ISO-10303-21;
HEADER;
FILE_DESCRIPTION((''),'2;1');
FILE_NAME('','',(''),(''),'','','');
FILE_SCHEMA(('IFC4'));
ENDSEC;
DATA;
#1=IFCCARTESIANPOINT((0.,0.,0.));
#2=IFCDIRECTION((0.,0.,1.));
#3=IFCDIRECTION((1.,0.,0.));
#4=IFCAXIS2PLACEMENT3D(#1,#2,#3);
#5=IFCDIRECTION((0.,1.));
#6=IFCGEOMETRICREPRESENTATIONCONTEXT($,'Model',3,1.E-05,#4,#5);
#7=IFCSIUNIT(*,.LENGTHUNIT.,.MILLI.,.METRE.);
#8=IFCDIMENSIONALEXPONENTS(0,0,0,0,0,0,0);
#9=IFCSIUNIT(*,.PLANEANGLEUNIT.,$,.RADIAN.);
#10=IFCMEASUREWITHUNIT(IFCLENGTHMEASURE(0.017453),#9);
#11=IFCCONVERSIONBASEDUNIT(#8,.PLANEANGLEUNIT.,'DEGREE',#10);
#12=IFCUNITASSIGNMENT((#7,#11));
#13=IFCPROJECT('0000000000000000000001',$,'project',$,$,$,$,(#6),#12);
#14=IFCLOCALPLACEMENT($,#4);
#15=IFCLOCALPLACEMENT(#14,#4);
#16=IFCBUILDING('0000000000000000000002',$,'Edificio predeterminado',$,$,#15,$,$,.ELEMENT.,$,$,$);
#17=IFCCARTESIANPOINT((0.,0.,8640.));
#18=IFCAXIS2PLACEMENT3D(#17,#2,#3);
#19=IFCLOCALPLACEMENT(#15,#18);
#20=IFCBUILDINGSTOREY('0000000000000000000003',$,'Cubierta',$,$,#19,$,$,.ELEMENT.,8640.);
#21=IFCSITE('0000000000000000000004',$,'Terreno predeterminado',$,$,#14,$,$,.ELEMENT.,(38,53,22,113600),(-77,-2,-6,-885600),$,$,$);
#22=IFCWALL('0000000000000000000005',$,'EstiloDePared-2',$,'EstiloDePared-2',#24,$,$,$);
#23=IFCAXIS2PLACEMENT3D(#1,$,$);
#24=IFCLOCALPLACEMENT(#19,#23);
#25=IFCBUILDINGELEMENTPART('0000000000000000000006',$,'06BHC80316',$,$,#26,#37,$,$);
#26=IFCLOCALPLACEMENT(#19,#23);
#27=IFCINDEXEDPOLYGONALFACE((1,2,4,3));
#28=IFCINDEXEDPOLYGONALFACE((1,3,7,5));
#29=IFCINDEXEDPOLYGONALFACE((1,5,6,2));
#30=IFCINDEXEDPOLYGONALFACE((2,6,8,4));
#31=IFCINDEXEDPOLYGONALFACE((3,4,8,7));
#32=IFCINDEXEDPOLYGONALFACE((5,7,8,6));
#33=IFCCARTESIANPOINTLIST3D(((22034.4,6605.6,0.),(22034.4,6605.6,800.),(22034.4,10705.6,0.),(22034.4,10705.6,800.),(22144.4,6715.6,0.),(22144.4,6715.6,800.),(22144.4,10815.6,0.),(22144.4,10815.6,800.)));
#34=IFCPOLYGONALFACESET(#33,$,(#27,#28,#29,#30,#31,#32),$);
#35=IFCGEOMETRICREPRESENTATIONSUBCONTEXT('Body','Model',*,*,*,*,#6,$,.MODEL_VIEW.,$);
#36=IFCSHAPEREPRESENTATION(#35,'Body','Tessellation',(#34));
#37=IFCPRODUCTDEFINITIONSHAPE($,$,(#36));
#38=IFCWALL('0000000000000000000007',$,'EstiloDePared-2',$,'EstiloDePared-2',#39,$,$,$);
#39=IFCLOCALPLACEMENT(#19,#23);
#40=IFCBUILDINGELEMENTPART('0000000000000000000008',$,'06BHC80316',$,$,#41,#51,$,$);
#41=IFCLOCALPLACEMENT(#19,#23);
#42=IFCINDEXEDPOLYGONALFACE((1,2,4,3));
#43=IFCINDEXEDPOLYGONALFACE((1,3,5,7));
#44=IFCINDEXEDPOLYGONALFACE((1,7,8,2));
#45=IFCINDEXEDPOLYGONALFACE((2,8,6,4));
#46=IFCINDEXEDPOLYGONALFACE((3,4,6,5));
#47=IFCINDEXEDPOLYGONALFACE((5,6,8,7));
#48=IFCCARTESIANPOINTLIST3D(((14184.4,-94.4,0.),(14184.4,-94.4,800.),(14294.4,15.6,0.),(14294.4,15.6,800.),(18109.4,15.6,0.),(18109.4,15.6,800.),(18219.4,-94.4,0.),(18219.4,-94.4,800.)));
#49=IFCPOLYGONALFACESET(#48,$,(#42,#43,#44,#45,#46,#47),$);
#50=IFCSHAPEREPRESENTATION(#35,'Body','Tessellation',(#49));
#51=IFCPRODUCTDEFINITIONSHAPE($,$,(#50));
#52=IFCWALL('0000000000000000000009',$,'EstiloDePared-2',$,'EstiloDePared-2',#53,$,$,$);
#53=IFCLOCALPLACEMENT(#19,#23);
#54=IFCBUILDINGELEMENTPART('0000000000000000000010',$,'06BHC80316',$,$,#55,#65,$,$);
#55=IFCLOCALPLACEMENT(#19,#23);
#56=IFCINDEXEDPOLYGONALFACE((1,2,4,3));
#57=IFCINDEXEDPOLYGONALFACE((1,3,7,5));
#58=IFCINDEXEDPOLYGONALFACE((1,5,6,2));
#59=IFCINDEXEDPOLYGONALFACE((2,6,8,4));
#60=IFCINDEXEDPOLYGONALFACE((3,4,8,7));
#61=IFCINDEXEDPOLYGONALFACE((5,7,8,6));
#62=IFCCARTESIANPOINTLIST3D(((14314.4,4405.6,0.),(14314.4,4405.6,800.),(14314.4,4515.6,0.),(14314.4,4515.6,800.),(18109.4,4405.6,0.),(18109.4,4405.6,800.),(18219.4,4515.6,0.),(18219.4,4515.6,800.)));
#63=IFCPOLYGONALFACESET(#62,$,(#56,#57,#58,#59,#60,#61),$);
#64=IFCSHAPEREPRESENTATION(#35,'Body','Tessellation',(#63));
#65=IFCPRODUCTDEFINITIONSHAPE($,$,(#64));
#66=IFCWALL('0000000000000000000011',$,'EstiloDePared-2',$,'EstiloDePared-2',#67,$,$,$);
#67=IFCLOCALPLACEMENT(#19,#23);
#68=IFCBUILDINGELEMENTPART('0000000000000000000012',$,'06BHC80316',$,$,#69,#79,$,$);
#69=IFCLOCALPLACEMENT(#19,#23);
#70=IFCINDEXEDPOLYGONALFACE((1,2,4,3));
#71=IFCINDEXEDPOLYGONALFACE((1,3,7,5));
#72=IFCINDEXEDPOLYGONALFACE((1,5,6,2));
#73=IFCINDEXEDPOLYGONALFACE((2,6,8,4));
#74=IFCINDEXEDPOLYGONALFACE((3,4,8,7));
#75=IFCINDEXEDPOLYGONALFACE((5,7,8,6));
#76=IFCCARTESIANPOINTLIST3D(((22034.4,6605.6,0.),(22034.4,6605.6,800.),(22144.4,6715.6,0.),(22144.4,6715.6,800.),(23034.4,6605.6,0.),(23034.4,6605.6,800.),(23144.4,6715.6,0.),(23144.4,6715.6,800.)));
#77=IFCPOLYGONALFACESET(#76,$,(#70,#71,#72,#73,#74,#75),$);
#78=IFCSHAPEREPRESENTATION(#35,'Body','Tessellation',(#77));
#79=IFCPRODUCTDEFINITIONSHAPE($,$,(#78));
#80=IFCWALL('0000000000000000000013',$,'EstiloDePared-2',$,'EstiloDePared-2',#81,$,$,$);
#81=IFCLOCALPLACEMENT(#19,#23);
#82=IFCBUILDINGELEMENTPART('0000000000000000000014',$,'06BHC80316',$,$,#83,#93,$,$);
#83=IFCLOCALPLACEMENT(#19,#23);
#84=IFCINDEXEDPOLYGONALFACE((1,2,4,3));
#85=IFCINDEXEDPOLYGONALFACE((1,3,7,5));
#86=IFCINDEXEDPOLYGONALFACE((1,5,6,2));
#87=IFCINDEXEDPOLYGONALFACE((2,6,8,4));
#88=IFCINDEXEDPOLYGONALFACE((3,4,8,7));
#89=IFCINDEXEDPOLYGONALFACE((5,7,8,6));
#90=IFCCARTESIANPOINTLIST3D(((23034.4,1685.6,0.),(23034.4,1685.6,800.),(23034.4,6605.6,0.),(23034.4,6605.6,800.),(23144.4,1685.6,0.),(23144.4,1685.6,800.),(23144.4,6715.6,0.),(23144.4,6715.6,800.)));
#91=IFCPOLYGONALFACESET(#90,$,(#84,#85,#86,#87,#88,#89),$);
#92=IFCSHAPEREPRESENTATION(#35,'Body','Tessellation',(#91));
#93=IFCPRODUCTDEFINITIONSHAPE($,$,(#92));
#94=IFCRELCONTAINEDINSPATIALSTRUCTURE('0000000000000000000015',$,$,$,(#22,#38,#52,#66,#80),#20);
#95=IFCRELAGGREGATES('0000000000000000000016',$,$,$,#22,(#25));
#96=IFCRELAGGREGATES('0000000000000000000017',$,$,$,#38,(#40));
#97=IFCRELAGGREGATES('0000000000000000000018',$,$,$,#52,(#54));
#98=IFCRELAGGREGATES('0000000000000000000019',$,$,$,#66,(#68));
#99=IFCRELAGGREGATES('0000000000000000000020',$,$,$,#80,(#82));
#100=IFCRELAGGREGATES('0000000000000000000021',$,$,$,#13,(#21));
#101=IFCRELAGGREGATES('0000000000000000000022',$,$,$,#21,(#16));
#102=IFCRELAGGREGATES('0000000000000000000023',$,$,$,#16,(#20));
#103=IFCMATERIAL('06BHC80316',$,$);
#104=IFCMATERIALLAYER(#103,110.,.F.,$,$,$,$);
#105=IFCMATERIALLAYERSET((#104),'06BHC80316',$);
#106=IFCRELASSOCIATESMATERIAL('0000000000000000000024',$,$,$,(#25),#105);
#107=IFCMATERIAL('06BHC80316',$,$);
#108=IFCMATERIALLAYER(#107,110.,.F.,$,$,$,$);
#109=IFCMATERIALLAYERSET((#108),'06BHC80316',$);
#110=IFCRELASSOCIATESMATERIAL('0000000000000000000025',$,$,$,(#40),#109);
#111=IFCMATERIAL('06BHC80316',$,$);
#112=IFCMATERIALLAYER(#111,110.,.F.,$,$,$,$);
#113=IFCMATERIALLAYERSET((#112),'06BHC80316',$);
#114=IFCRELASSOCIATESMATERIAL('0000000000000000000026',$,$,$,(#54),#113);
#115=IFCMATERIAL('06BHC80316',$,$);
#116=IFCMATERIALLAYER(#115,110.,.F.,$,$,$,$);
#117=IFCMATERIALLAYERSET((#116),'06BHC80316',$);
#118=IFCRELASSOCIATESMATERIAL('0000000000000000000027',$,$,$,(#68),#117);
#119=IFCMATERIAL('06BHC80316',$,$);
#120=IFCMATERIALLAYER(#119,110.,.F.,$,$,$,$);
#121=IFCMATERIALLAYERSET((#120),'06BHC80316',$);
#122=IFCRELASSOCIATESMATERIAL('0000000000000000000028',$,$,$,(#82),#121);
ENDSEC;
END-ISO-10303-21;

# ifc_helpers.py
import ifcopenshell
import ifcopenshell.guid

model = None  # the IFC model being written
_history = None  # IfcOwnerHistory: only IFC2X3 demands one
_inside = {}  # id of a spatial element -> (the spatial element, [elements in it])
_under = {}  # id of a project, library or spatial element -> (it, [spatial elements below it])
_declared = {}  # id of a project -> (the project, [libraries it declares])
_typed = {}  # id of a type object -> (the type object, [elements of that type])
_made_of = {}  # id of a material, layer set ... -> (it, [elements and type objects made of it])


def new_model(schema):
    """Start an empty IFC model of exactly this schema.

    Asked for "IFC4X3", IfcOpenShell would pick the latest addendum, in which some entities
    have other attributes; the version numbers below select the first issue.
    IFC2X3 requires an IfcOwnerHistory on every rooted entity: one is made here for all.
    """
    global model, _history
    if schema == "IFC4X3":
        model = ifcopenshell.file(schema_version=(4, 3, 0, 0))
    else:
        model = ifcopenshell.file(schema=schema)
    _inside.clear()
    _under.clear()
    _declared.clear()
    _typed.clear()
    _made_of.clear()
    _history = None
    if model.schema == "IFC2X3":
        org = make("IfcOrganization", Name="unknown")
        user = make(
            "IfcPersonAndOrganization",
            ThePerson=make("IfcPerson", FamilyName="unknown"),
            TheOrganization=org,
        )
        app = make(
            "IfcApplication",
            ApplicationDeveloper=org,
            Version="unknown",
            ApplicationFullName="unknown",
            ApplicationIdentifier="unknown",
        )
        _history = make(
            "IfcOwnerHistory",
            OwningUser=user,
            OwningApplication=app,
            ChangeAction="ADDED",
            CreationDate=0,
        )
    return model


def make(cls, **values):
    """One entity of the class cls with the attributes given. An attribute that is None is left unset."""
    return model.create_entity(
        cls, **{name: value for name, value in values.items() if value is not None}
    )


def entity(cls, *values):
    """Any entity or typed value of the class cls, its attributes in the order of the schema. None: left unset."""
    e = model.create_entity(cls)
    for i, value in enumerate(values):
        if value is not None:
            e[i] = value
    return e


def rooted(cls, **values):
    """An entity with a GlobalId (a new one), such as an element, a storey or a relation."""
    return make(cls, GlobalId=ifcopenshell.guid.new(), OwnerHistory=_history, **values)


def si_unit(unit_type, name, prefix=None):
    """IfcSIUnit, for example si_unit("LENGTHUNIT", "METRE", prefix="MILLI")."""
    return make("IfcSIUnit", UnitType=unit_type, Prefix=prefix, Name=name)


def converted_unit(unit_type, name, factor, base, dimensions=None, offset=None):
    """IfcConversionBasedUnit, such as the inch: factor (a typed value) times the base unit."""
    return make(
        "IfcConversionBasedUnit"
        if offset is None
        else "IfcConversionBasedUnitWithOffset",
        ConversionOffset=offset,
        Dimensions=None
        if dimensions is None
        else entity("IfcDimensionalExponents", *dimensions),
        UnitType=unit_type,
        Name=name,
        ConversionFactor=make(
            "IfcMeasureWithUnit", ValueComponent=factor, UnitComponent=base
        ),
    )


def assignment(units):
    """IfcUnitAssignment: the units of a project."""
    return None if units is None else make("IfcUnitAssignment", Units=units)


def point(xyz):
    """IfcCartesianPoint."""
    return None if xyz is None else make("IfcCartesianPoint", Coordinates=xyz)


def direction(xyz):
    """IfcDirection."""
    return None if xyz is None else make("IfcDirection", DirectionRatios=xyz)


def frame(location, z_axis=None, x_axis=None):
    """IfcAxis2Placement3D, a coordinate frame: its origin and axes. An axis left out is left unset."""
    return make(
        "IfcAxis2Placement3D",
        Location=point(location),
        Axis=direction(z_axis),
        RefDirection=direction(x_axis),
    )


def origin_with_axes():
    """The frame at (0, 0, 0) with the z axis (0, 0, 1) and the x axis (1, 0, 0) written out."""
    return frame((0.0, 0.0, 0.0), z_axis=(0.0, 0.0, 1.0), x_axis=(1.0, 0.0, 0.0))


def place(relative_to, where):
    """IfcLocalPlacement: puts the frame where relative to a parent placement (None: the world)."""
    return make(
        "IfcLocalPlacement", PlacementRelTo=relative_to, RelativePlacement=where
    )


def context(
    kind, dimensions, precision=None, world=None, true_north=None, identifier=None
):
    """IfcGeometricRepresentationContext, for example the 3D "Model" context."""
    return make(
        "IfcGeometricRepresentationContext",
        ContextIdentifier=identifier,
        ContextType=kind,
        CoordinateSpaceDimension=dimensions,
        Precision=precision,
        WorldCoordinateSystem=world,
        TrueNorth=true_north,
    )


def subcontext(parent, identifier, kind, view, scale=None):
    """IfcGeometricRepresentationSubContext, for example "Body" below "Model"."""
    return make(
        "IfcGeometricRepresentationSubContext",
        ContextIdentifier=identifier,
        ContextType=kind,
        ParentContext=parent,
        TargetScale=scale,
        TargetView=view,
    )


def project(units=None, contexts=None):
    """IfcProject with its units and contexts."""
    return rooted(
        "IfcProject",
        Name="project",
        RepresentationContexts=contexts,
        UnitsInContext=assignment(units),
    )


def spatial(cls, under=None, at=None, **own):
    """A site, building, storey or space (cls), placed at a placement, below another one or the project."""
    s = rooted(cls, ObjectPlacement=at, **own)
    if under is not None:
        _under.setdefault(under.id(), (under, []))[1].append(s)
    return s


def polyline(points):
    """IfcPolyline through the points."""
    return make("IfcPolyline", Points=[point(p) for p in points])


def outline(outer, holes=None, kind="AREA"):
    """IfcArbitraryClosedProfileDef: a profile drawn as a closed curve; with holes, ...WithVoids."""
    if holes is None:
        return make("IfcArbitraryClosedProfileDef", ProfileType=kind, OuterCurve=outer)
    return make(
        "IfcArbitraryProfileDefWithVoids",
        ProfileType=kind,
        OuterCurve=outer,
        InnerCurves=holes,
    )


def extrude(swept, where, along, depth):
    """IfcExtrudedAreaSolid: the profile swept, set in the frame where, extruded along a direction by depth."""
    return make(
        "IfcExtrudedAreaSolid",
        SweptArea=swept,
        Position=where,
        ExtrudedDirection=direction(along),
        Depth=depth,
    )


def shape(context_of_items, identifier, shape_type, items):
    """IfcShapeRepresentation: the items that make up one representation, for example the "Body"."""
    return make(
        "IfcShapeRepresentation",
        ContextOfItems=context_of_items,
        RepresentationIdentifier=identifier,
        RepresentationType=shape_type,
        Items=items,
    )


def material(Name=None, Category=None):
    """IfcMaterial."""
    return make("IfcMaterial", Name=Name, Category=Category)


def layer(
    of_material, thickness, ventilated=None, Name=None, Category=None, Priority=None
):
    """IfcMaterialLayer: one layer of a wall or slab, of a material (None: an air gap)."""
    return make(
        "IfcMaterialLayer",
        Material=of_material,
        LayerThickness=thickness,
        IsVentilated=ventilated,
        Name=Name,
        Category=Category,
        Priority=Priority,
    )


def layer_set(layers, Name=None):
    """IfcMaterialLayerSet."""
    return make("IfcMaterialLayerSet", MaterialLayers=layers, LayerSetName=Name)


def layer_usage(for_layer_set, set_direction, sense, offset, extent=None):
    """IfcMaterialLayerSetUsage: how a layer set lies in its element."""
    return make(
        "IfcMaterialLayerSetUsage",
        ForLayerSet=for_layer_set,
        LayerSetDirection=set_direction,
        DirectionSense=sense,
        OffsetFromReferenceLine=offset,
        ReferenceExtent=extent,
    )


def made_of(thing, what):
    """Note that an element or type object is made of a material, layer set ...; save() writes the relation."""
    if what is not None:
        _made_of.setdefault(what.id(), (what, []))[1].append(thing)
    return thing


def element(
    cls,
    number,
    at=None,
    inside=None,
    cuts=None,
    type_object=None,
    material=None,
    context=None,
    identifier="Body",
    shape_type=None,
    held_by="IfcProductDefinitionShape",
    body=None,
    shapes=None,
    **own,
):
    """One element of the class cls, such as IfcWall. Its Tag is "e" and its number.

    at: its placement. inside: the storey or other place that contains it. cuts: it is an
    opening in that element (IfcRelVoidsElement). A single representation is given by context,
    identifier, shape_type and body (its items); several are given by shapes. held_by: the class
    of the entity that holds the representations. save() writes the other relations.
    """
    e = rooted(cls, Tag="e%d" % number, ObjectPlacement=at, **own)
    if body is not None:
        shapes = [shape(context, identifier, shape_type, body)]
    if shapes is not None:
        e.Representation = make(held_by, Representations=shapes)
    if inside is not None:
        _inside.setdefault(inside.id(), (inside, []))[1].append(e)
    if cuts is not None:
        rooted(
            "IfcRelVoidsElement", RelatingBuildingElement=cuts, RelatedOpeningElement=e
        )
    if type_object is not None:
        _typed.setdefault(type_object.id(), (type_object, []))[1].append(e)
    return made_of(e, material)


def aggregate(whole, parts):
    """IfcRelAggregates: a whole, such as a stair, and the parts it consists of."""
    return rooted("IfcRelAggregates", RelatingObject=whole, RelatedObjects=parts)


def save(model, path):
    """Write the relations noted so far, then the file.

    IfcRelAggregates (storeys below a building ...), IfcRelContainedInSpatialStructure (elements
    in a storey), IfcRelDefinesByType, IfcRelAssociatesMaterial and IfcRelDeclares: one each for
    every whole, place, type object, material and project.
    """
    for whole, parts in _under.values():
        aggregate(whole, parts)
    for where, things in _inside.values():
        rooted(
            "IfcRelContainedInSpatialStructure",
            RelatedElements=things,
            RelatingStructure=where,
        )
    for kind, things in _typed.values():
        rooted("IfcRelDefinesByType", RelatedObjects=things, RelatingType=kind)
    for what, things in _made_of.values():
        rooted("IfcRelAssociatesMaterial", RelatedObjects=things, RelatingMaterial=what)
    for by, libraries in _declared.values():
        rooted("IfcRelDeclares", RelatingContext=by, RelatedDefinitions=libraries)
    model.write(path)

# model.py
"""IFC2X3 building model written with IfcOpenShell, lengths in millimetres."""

from ifc_helpers import new_model, entity, si_unit, converted_unit, direction, frame, origin_with_axes, place, context, subcontext, project, spatial, polyline, outline, extrude, material, layer, layer_set, layer_usage, element, aggregate, save


model = new_model("IFC2X3")

# Units and contexts
model_context = context("Model", 3, precision=1e-05, world=origin_with_axes(), true_north=direction((0.0, 1.0)))
body_context = subcontext(model_context, "Body", "Model", "MODEL_VIEW")
ifc_project = project(units=[si_unit("LENGTHUNIT", "METRE", prefix="MILLI"), converted_unit("PLANEANGLEUNIT", "DEGREE", entity("IfcLengthMeasure", 0.017453), si_unit("PLANEANGLEUNIT", "RADIAN"), dimensions=[0, 0, 0, 0, 0, 0, 0])], contexts=[model_context])

# Site, building, storey
site_placement = place(None, origin_with_axes())
site = spatial("IfcSite", under=ifc_project, at=site_placement, Name="Terreno predeterminado", CompositionType="ELEMENT", RefLatitude=(38, 53, 22, 113600), RefLongitude=(-77, -2, -6, -885600))
building_placement = place(site_placement, origin_with_axes())
building = spatial("IfcBuilding", under=site, at=building_placement, Name="Edificio predeterminado", CompositionType="ELEMENT")
storey_placement = place(building_placement, frame((0.0, 0.0, 8640.0), z_axis=(0.0, 0.0, 1.0), x_axis=(1.0, 0.0, 0.0)))
storey = spatial("IfcBuildingStorey", under=building, at=storey_placement, Name="Cubierta", CompositionType="ELEMENT", Elevation=8640.0)

# Wall, building element part
wall_1_placement = place(storey_placement, frame((22089.4, 10760.6, 0.0), z_axis=(0.0, 0.0, 1.0), x_axis=(0.0, -1.0, 0.0)))
wall_1 = element("IfcWall", 1, at=wall_1_placement, inside=storey, Name="EstiloDePared-2", ObjectType="EstiloDePared-2")
ifc_material_1 = material(Name="06BHC80316")
ifc_layer_1 = layer(ifc_material_1, 110.0, ventilated=False)
ifc_layer_set_1 = layer_set([ifc_layer_1], Name="06BHC80316")
ifc_layer_usage_1 = layer_usage(ifc_layer_set_1, "AXIS2", "NEGATIVE", -55.0)
building_element_part_1_placement = place(wall_1_placement, origin_with_axes())
building_element_part_1 = element("IfcBuildingElementPart", 2, at=building_element_part_1_placement, material=ifc_layer_usage_1, Name="06BHC80316", context=body_context, shape_type="SweptSolid", body=[
    extrude(outline(polyline([(4045.0, 55.0), (4155.0, -55.0), (55.0, -55.0), (-55.0, 55.0), (4045.0, 55.0)])), origin_with_axes(), (0.0, 0.0, 1.0), 800.0),
])
aggregate(wall_1, [building_element_part_1])

# Walls, building element parts
wall_2_placement = place(storey_placement, frame((18164.4, -39.4, 0.0), z_axis=(0.0, 0.0, 1.0), x_axis=(-1.0, 0.0, 0.0)))
wall_2 = element("IfcWall", 3, at=wall_2_placement, inside=storey, Name="EstiloDePared-2", ObjectType="EstiloDePared-2")
ifc_material_2 = material(Name="06BHC80316")
ifc_layer_2 = layer(ifc_material_2, 110.0, ventilated=False)
ifc_layer_set_2 = layer_set([ifc_layer_2], Name="06BHC80316")
ifc_layer_usage_2 = layer_usage(ifc_layer_set_2, "AXIS2", "NEGATIVE", -55.0)
building_element_part_2_placement = place(wall_2_placement, origin_with_axes())
building_element_part_2 = element("IfcBuildingElementPart", 4, at=building_element_part_2_placement, material=ifc_layer_usage_2, Name="06BHC80316", context=body_context, shape_type="SweptSolid", body=[
    extrude(outline(polyline([(3980.0, 55.0), (3870.0, -55.0), (55.0, -55.0), (-55.0, 55.0), (3980.0, 55.0)])), origin_with_axes(), (0.0, 0.0, 1.0), 800.0),
])
aggregate(wall_2, [building_element_part_2])
wall_3_placement = place(storey_placement, frame((18164.4, 4460.6, 0.0), z_axis=(0.0, 0.0, 1.0), x_axis=(-1.0, 0.0, 0.0)))
wall_3 = element("IfcWall", 5, at=wall_3_placement, inside=storey, Name="EstiloDePared-2", ObjectType="EstiloDePared-2")
ifc_material_3 = material(Name="06BHC80316")
ifc_layer_3 = layer(ifc_material_3, 110.0, ventilated=False)
ifc_layer_set_3 = layer_set([ifc_layer_3], Name="06BHC80316")
ifc_layer_usage_3 = layer_usage(ifc_layer_set_3, "AXIS2", "NEGATIVE", -55.0)
building_element_part_3_placement = place(wall_3_placement, origin_with_axes())
building_element_part_3 = element("IfcBuildingElementPart", 6, at=building_element_part_3_placement, material=ifc_layer_usage_3, Name="06BHC80316", context=body_context, shape_type="SweptSolid", body=[
    extrude(outline(polyline([(3850.0, 55.0), (3850.0, -55.0), (-55.0, -55.0), (55.0, 55.0), (3850.0, 55.0)])), origin_with_axes(), (0.0, 0.0, 1.0), 800.0),
])
aggregate(wall_3, [building_element_part_3])
wall_4_placement = place(storey_placement, frame((22089.4, 6660.6, 0.0), z_axis=(0.0, 0.0, 1.0), x_axis=(1.0, 0.0, 0.0)))
wall_4 = element("IfcWall", 7, at=wall_4_placement, inside=storey, Name="EstiloDePared-2", ObjectType="EstiloDePared-2")
ifc_material_4 = material(Name="06BHC80316")
ifc_layer_4 = layer(ifc_material_4, 110.0, ventilated=False)
ifc_layer_set_4 = layer_set([ifc_layer_4], Name="06BHC80316")
ifc_layer_usage_4 = layer_usage(ifc_layer_set_4, "AXIS2", "NEGATIVE", -55.0)
building_element_part_4_placement = place(wall_4_placement, origin_with_axes())
building_element_part_4 = element("IfcBuildingElementPart", 8, at=building_element_part_4_placement, material=ifc_layer_usage_4, Name="06BHC80316", context=body_context, shape_type="SweptSolid", body=[
    extrude(outline(polyline([(1055.0, 55.0), (945.0, -55.0), (-55.0, -55.0), (55.0, 55.0), (1055.0, 55.0)])), origin_with_axes(), (0.0, 0.0, 1.0), 800.0),
])
aggregate(wall_4, [building_element_part_4])
wall_5_placement = place(storey_placement, frame((23089.4, 6660.6, 0.0), z_axis=(0.0, 0.0, 1.0), x_axis=(0.0, -1.0, 0.0)))
wall_5 = element("IfcWall", 9, at=wall_5_placement, inside=storey, Name="EstiloDePared-2", ObjectType="EstiloDePared-2")
ifc_material_5 = material(Name="06BHC80316")
ifc_layer_5 = layer(ifc_material_5, 110.0, ventilated=False)
ifc_layer_set_5 = layer_set([ifc_layer_5], Name="06BHC80316")
ifc_layer_usage_5 = layer_usage(ifc_layer_set_5, "AXIS2", "NEGATIVE", -55.0)
building_element_part_5_placement = place(wall_5_placement, origin_with_axes())
building_element_part_5 = element("IfcBuildingElementPart", 10, at=building_element_part_5_placement, material=ifc_layer_usage_5, Name="06BHC80316", context=body_context, shape_type="SweptSolid", body=[
    extrude(outline(polyline([(4975.0, 55.0), (4975.0, -55.0), (55.0, -55.0), (-55.0, 55.0), (4975.0, 55.0)])), origin_with_axes(), (0.0, 0.0, 1.0), 800.0),
])
aggregate(wall_5, [building_element_part_5])

save(model, "model.ifc")
